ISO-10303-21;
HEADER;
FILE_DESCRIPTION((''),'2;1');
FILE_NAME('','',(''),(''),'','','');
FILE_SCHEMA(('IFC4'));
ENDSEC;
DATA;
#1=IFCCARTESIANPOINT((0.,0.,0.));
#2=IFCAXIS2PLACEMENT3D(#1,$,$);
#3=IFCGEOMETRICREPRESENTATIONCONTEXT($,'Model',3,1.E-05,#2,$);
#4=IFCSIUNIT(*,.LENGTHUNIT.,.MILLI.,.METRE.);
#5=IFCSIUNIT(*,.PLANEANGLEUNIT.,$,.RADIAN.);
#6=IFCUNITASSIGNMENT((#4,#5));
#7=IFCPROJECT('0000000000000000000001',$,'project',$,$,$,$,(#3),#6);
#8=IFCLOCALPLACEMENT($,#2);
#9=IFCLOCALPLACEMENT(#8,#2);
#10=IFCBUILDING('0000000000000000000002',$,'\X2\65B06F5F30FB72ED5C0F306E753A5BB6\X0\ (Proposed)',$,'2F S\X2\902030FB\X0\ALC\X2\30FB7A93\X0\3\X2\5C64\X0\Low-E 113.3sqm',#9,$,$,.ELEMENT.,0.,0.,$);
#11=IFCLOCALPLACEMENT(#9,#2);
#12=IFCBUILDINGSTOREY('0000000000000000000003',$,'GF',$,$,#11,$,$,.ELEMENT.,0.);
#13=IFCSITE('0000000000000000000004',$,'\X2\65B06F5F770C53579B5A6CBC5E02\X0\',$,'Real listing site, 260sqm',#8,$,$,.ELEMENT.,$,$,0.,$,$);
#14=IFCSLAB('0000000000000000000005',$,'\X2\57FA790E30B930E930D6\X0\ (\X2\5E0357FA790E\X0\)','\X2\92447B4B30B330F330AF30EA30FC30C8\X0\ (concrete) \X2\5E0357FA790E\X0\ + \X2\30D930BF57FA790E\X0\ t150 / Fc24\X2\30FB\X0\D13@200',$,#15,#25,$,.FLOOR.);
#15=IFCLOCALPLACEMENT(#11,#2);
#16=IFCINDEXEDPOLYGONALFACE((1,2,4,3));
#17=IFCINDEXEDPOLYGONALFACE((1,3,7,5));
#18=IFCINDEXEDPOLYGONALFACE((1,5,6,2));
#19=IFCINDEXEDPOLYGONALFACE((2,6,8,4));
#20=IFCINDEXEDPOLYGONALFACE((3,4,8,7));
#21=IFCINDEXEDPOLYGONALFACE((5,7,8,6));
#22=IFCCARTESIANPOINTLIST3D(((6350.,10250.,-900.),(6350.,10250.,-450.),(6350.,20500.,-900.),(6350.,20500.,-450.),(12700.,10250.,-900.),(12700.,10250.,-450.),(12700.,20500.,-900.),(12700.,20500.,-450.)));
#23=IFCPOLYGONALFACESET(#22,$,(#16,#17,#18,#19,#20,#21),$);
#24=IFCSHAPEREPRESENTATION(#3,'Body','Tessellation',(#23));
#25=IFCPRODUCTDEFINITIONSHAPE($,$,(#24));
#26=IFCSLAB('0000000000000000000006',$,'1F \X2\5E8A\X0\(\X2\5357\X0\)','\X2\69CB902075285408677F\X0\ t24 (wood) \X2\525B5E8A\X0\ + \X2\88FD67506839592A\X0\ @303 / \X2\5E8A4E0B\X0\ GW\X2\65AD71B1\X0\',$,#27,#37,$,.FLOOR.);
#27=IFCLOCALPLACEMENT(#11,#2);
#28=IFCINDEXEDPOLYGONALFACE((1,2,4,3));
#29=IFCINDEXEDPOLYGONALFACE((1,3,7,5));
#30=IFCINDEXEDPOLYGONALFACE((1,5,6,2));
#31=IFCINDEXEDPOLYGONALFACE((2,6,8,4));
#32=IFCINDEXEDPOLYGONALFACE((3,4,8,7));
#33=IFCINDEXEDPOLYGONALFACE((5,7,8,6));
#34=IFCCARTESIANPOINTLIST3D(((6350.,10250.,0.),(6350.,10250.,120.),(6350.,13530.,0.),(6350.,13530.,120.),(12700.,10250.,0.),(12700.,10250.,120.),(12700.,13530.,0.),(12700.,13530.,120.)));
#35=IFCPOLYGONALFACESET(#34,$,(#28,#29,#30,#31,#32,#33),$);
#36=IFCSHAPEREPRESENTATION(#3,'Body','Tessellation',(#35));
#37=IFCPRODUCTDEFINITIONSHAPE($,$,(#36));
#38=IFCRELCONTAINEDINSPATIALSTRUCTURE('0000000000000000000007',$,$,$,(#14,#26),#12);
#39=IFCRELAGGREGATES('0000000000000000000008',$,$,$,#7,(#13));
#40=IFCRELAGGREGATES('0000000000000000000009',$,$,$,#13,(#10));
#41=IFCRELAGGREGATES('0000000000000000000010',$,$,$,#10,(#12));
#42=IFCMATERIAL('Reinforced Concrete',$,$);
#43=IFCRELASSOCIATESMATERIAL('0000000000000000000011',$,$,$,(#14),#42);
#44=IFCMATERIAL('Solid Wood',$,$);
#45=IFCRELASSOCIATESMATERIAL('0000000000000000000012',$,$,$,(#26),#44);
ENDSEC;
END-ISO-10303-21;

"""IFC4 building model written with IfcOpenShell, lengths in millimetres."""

from ifc_helpers import new_model, si_unit, frame, frame_2d, origin, place, context, project, spatial, rectangle, extrude, material, element, save


model = new_model("IFC4")

# Units and contexts
model_context = context("Model", 3, precision=1e-05, world=origin())
ifc_project = project(units=[si_unit("LENGTHUNIT", "METRE", prefix="MILLI"), si_unit("PLANEANGLEUNIT", "RADIAN")], contexts=[model_context])

# Site, building, storey
site_placement = place(None, origin())
site = spatial("IfcSite", under=ifc_project, at=site_placement, Name="新潟県南魚沼市", ObjectType="Real listing site, 260sqm", CompositionType="ELEMENT", RefElevation=0.0)
building_placement = place(site_placement, origin())
building = spatial("IfcBuilding", under=site, at=building_placement, Name="新潟・狭小の町家 (Proposed)", ObjectType="2F S造・ALC・窓3層Low-E 113.3sqm", CompositionType="ELEMENT", ElevationOfRefHeight=0.0, ElevationOfTerrain=0.0)
storey_placement = place(building_placement, origin())
storey = spatial("IfcBuildingStorey", under=building, at=storey_placement, Name="GF", CompositionType="ELEMENT", Elevation=0.0)

# Shared definitions
ifc_material_1 = material(Name="Solid Wood")

# Slabs
ifc_material_2 = material(Name="Reinforced Concrete")
slab_1_placement = place(storey_placement, frame((3175.0, 5125.0, -450.0)))
element("IfcSlab", 1, at=slab_1_placement, inside=storey, material=ifc_material_2, Name="基礎スラブ (布基礎)", Description="鉄筋コンクリート (concrete) 布基礎 + ベタ基礎 t150 / Fc24・D13@200", PredefinedType="FLOOR", context=model_context, shape_type="SweptSolid", body=[
    extrude(rectangle(XDim=6350.0, YDim=10250.0, at=frame_2d((3175.0, 5125.0))), frame((3175.0, 5125.0, -450.0)), (0.0, 0.0, 1.0), 450.0),
])
slab_2_placement = place(storey_placement, frame((3175.0, 5125.0, 0.0)))
element("IfcSlab", 2, at=slab_2_placement, inside=storey, material=ifc_material_1, Name="1F 床(南)", Description="構造用合板 t24 (wood) 剛床 + 製材根太 @303 / 床下 GW断熱", PredefinedType="FLOOR", context=model_context, shape_type="SweptSolid", body=[
    extrude(rectangle(XDim=6350.0, YDim=3280.0, at=frame_2d((3175.0, 1640.0))), frame((3175.0, 5125.0, 0.0)), (0.0, 0.0, 1.0), 120.0),
])

save(model, "model.ifc")
